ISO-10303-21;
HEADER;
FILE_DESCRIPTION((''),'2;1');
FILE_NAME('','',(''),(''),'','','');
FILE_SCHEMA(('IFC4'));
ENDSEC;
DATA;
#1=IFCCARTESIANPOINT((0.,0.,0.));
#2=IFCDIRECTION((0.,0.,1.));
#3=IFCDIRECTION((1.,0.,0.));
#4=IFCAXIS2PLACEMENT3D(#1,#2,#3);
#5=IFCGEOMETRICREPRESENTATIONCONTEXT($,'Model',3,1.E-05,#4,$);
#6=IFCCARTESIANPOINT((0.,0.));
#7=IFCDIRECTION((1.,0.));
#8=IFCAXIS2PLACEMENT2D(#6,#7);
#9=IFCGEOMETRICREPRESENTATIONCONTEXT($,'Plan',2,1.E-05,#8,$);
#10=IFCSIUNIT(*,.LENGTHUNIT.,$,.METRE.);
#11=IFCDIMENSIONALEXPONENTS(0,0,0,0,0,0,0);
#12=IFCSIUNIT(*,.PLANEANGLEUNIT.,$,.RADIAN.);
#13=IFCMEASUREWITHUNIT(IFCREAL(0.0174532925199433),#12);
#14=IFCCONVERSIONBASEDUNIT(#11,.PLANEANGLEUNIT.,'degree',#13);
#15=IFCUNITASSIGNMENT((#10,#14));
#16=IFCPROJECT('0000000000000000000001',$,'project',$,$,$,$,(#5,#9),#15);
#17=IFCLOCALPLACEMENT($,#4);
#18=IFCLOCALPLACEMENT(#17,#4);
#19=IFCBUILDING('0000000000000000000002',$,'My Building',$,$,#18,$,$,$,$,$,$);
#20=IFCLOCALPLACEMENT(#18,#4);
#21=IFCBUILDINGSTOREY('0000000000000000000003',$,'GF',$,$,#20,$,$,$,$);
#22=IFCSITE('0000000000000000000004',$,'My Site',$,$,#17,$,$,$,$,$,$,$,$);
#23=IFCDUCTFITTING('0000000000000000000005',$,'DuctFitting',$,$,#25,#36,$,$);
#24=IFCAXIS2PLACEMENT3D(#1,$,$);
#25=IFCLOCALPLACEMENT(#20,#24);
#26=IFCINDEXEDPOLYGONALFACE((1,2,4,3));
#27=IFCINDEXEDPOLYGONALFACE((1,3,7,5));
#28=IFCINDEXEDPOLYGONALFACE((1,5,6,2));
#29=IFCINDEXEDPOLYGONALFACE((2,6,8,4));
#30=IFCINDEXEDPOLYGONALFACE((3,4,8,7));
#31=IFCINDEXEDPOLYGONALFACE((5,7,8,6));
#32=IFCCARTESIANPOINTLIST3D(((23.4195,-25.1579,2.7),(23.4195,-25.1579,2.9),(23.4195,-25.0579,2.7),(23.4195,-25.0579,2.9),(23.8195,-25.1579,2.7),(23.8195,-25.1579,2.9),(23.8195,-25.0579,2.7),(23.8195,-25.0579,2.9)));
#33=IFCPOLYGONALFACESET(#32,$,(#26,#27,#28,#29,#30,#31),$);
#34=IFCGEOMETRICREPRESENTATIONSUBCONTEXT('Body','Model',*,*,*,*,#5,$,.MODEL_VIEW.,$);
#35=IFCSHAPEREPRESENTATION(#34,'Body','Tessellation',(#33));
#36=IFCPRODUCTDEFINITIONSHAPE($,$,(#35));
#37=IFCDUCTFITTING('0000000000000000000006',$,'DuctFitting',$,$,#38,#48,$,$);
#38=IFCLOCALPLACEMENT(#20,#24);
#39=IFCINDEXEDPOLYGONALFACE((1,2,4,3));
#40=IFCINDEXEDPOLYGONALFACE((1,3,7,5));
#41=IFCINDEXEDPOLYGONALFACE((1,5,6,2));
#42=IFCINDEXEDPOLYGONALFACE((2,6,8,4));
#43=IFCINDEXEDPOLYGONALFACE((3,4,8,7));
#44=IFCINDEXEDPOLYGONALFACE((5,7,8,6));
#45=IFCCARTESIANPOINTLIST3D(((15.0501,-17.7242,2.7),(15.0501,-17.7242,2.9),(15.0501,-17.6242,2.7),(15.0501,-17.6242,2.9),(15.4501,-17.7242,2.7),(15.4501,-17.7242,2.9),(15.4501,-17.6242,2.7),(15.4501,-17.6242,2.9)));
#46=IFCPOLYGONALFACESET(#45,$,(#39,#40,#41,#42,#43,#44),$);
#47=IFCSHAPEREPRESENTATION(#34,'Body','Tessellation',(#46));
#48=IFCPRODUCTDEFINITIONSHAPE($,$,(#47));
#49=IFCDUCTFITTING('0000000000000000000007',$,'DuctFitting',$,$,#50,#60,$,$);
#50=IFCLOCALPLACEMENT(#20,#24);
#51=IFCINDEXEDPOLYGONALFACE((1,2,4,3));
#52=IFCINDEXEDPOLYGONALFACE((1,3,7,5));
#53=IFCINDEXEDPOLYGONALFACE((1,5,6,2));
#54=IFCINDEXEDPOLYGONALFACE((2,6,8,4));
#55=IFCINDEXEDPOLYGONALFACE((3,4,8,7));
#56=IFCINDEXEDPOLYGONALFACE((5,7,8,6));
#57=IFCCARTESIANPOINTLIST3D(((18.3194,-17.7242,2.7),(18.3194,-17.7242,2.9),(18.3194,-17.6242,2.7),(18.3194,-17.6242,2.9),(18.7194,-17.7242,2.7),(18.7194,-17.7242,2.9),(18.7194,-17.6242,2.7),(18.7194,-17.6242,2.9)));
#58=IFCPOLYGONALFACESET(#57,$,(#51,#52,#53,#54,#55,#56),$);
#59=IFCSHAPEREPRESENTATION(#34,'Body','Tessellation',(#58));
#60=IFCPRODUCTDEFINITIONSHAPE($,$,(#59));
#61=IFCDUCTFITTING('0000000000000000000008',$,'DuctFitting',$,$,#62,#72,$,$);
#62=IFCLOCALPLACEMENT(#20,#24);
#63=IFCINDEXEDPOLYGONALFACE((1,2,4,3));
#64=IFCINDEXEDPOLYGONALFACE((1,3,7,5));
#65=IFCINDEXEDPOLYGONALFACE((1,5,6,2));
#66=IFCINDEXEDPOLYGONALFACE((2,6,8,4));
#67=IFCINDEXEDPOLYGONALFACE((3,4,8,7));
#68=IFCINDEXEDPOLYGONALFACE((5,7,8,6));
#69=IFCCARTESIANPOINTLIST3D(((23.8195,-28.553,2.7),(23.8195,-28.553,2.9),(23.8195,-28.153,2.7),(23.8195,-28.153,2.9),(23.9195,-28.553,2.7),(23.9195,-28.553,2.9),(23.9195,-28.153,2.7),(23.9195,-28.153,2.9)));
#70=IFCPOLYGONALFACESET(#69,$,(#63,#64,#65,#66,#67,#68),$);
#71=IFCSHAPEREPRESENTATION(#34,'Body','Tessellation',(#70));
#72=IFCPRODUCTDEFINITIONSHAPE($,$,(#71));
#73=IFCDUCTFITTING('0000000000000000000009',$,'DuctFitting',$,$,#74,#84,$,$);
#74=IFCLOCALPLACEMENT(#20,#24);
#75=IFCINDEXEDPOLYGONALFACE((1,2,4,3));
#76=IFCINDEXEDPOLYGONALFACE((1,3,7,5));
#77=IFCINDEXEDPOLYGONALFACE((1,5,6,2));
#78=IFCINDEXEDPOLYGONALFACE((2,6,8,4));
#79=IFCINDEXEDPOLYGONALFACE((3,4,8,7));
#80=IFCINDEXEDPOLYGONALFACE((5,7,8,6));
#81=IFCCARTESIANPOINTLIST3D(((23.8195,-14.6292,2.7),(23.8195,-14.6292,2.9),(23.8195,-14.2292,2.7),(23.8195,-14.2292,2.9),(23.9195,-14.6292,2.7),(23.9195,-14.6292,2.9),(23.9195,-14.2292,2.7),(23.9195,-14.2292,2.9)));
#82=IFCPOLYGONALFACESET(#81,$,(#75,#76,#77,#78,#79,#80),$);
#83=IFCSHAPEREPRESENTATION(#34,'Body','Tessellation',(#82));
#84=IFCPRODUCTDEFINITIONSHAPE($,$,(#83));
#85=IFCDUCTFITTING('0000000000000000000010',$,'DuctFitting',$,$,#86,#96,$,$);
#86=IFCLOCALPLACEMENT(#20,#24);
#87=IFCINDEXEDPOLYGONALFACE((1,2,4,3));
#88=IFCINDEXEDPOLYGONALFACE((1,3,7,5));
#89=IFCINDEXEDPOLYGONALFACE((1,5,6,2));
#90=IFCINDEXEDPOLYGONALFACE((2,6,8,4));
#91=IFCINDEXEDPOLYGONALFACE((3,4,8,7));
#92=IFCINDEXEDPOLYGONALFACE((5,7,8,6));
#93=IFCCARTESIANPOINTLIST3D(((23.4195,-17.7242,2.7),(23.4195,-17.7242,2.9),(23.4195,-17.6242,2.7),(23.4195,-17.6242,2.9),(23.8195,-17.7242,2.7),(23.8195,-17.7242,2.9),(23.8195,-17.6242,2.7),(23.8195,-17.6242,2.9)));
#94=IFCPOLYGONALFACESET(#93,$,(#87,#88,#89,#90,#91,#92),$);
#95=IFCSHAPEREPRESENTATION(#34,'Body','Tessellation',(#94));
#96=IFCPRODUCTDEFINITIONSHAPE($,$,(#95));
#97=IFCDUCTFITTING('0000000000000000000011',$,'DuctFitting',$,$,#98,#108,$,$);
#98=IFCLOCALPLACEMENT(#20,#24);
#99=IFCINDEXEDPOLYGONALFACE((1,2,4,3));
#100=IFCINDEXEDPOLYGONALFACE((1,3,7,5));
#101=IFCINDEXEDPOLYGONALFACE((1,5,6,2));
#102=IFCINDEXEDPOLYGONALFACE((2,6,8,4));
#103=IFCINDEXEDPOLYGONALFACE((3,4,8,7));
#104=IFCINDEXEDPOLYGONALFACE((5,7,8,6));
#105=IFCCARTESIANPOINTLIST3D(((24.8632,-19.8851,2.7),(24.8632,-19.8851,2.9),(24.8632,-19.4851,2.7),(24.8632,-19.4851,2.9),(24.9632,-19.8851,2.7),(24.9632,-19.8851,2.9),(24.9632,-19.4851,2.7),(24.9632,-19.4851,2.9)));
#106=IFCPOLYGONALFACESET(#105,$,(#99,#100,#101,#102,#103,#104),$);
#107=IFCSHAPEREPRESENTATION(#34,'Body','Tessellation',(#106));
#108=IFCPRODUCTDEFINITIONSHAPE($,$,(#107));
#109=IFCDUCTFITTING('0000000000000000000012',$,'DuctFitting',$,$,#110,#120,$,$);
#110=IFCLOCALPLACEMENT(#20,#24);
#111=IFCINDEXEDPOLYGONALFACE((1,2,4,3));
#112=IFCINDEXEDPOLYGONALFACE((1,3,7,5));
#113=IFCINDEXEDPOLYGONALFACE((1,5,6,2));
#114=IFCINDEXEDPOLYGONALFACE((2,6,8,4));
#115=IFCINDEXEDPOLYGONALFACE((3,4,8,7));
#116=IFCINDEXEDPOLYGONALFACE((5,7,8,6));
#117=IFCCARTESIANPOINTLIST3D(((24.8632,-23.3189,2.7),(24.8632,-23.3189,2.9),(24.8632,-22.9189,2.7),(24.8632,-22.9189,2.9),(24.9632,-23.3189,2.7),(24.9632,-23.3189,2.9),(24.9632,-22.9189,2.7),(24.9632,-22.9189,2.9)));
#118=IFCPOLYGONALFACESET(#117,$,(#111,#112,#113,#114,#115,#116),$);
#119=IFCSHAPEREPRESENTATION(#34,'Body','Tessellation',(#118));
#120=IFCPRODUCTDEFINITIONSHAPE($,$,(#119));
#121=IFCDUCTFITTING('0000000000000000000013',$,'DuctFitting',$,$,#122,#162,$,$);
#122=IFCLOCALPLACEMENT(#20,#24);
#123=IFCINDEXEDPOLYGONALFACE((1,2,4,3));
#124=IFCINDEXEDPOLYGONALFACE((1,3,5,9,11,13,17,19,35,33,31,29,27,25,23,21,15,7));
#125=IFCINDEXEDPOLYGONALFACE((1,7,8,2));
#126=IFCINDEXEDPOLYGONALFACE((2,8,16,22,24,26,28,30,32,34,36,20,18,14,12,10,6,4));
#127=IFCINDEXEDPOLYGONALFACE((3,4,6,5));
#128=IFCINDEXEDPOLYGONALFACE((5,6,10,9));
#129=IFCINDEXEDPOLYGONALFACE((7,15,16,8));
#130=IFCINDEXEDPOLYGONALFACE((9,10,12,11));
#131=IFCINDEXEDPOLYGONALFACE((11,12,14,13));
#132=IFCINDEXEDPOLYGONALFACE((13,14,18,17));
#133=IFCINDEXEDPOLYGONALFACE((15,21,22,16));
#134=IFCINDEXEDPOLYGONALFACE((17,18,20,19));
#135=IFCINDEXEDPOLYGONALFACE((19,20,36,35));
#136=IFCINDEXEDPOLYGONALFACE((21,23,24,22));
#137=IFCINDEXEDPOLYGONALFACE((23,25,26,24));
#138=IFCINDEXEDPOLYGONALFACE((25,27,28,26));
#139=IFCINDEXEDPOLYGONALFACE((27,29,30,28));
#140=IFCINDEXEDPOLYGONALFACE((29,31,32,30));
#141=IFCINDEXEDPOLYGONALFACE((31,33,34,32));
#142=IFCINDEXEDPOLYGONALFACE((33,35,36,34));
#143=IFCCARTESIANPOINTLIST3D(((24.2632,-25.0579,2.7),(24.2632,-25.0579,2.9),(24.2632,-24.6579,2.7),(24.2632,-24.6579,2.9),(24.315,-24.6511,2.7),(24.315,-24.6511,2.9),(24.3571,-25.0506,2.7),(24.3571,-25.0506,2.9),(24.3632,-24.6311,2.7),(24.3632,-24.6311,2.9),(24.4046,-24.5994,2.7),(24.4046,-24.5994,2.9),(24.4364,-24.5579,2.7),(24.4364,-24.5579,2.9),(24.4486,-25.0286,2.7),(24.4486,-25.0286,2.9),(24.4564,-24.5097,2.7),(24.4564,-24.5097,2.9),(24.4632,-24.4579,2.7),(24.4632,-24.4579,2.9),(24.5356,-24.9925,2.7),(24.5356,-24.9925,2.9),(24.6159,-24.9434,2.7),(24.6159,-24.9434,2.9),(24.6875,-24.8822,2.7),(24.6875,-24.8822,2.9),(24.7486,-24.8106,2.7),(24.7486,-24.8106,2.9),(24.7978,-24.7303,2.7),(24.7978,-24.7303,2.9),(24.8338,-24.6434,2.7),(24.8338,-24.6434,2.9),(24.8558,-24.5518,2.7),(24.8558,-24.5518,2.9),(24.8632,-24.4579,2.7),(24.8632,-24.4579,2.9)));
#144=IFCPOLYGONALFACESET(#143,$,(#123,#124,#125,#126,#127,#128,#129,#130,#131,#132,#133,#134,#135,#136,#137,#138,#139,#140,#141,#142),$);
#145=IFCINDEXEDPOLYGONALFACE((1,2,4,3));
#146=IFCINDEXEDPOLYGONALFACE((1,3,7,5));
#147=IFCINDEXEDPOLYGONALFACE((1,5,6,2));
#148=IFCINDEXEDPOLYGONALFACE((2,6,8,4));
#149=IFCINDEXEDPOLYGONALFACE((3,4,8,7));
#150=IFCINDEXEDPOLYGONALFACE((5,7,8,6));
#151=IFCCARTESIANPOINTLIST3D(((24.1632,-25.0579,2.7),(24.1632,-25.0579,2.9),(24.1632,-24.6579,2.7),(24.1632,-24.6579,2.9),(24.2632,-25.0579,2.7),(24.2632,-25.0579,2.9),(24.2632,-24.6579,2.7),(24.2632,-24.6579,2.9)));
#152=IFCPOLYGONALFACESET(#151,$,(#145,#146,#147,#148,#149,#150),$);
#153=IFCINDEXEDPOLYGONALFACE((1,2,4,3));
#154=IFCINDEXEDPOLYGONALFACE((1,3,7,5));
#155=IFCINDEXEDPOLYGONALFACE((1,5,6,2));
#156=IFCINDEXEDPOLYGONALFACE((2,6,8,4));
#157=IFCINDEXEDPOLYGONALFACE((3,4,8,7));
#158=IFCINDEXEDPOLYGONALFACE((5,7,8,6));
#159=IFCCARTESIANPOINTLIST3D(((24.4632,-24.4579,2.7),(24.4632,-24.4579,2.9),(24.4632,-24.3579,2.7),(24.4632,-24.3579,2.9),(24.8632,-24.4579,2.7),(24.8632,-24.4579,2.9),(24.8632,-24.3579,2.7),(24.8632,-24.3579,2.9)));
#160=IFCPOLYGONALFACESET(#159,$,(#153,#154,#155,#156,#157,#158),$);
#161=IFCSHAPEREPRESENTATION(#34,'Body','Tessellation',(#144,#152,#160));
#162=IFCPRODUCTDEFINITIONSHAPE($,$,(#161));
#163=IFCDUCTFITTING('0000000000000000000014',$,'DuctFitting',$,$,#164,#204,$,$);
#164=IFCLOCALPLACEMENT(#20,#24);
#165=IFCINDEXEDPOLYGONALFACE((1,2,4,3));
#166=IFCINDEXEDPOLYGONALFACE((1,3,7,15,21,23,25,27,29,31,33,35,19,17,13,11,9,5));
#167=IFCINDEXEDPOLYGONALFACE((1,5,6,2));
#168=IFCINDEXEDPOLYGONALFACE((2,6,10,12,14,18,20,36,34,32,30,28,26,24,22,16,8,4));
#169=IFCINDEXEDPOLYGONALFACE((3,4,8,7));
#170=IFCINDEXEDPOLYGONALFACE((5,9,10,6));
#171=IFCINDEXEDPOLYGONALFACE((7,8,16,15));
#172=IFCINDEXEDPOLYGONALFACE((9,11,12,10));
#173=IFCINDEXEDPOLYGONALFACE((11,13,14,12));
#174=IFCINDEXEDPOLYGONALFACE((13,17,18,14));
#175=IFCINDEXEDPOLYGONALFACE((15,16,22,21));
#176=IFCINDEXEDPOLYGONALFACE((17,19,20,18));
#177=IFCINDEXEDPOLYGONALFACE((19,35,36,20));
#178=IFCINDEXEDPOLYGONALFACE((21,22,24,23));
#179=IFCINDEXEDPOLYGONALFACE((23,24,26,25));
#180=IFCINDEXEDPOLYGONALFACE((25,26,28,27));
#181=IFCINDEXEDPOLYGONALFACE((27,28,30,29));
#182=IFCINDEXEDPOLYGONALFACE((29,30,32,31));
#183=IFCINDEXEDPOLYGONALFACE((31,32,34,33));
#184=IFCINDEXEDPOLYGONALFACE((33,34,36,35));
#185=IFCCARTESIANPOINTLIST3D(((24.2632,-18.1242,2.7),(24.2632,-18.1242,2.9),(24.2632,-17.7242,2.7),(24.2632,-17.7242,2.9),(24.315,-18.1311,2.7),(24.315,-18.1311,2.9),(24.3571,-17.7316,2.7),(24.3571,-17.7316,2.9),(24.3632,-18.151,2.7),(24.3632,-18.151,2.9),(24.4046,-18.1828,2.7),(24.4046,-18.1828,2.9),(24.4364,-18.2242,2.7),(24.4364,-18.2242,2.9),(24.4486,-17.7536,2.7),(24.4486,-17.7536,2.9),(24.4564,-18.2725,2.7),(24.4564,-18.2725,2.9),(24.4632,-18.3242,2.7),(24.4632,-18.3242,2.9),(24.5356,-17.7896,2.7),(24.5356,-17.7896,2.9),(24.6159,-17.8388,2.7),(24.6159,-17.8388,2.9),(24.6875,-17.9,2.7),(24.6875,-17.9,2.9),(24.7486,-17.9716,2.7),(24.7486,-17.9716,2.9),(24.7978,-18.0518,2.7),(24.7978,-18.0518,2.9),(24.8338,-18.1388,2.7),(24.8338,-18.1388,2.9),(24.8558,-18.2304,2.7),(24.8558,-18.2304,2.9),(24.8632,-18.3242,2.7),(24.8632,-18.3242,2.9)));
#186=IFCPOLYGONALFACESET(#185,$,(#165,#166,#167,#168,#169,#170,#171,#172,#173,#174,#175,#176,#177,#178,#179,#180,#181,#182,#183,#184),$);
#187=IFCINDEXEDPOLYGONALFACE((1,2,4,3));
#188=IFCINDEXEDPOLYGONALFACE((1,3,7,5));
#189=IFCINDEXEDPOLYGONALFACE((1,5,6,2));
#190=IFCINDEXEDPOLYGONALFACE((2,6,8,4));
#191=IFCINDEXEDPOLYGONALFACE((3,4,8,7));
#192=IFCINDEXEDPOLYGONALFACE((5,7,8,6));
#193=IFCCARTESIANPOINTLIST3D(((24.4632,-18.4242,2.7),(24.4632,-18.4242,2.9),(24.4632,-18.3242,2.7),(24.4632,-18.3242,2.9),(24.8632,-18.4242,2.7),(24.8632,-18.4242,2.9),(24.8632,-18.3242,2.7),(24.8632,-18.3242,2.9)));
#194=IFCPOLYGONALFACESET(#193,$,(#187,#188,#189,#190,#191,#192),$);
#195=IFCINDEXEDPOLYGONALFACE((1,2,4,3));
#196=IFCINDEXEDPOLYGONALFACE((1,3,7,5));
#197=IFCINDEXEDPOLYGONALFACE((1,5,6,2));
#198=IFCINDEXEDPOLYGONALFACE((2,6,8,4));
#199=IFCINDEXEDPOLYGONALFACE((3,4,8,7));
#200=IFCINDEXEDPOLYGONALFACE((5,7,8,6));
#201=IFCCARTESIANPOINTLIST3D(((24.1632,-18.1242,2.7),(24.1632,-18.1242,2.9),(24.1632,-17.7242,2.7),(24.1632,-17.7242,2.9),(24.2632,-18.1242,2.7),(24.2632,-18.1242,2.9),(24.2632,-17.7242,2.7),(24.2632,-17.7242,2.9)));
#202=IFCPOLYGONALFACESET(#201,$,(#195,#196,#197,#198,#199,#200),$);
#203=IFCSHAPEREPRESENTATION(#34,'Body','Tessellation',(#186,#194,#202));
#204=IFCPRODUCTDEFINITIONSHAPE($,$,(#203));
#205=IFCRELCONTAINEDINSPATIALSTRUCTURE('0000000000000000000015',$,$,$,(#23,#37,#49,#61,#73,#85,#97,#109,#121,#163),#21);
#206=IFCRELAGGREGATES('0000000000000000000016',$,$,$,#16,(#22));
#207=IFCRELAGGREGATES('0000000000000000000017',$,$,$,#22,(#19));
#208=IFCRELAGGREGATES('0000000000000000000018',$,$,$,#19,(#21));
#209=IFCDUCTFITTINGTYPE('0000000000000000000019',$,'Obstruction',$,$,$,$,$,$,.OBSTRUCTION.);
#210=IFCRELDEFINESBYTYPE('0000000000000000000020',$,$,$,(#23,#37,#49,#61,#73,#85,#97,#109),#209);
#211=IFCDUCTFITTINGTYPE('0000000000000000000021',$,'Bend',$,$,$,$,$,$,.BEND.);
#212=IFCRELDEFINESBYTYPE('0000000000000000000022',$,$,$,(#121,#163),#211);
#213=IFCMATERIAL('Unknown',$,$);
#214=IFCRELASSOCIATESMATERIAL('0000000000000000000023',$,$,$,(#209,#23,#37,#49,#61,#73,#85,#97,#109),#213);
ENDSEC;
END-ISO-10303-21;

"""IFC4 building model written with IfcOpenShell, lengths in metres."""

from ifc_helpers import new_model, entity, si_unit, converted_unit, frame, origin_with_axes, origin_2d_with_axis, place, context, subcontext, project, spatial, line, arc, indexed_curve, rectangle, outline, extrude, source, transform, mapped, material, material_profile, profile_set, profile_usage, type_object, type_shapes, element, save


model = new_model("IFC4")

# Units and contexts
model_context = context("Model", 3, precision=1e-05, world=origin_with_axes())
plan_context = context("Plan", 2, precision=1e-05, world=origin_2d_with_axis())
body_context_1 = subcontext(model_context, "Body", "Model", "MODEL_VIEW")
ifc_project = project(units=[si_unit("LENGTHUNIT", "METRE"), converted_unit("PLANEANGLEUNIT", "degree", entity("IfcReal", 0.0174532925199433), si_unit("PLANEANGLEUNIT", "RADIAN"), dimensions=[0, 0, 0, 0, 0, 0, 0])], contexts=[model_context, plan_context])

# Site, building, storey
site_placement = place(None, origin_with_axes())
site = spatial("IfcSite", under=ifc_project, at=site_placement, Name="My Site")
building_placement = place(site_placement, origin_with_axes())
building = spatial("IfcBuilding", under=site, at=building_placement, Name="My Building")
storey_placement = place(building_placement, origin_with_axes())
storey = spatial("IfcBuildingStorey", under=building, at=storey_placement, Name="GF")

# Shared definitions
ifc_material = material(Name="Unknown")

# Duct fittings
ifc_material_profile_1 = material_profile(ifc_material, rectangle(XDim=0.4, YDim=0.2))
ifc_profile_set_1 = profile_set([ifc_material_profile_1])
duct_fitting_type_1 = type_object("IfcDuctFittingType", Name="Obstruction", PredefinedType="OBSTRUCTION", material=ifc_profile_set_1)
ifc_profile_usage_1 = profile_usage(ifc_profile_set_1, cardinal=5)
duct_fitting_1_placement = place(storey_placement, frame((23.6195, -25.0579, 2.8), z_axis=(0.0, -1.0, 0.0), x_axis=(1.0, 0.0, 0.0)))
element("IfcDuctFitting", 1, at=duct_fitting_1_placement, inside=storey, type_object=duct_fitting_type_1, material=ifc_profile_usage_1, Name="DuctFitting", context=body_context_1, shape_type="SweptSolid", body=[
    extrude(rectangle(XDim=0.4, YDim=0.2), origin_with_axes(), (0.0, 0.0, 1.0), 0.1),
])
ifc_profile_usage_2 = profile_usage(ifc_profile_set_1, cardinal=5)
duct_fitting_2_placement = place(storey_placement, frame((15.2501, -17.7242, 2.8), z_axis=(0.0, 1.0, 0.0), x_axis=(-1.0, 0.0, 0.0)))
element("IfcDuctFitting", 2, at=duct_fitting_2_placement, inside=storey, type_object=duct_fitting_type_1, material=ifc_profile_usage_2, Name="DuctFitting", context=body_context_1, shape_type="SweptSolid", body=[
    extrude(rectangle(XDim=0.4, YDim=0.2), origin_with_axes(), (0.0, 0.0, 1.0), 0.1),
])
ifc_profile_usage_3 = profile_usage(ifc_profile_set_1, cardinal=5)
duct_fitting_3_placement = place(storey_placement, frame((18.5194, -17.7242, 2.8), z_axis=(0.0, 1.0, 0.0), x_axis=(-1.0, 0.0, 0.0)))
element("IfcDuctFitting", 3, at=duct_fitting_3_placement, inside=storey, type_object=duct_fitting_type_1, material=ifc_profile_usage_3, Name="DuctFitting", context=body_context_1, shape_type="SweptSolid", body=[
    extrude(rectangle(XDim=0.4, YDim=0.2), origin_with_axes(), (0.0, 0.0, 1.0), 0.1),
])
ifc_profile_usage_4 = profile_usage(ifc_profile_set_1, cardinal=5)
duct_fitting_4_placement = place(storey_placement, frame((23.8195, -28.353, 2.8), z_axis=(1.0, 0.0, 0.0), x_axis=(0.0, 1.0, 0.0)))
element("IfcDuctFitting", 4, at=duct_fitting_4_placement, inside=storey, type_object=duct_fitting_type_1, material=ifc_profile_usage_4, Name="DuctFitting", context=body_context_1, shape_type="SweptSolid", body=[
    extrude(rectangle(XDim=0.4, YDim=0.2), origin_with_axes(), (0.0, 0.0, 1.0), 0.1),
])
ifc_profile_usage_5 = profile_usage(ifc_profile_set_1, cardinal=5)
duct_fitting_5_placement = place(storey_placement, frame((23.8195, -14.4292, 2.8), z_axis=(1.0, 0.0, 0.00005), x_axis=(0.0, -1.0, 0.0)))
element("IfcDuctFitting", 5, at=duct_fitting_5_placement, inside=storey, type_object=duct_fitting_type_1, material=ifc_profile_usage_5, Name="DuctFitting", context=body_context_1, shape_type="SweptSolid", body=[
    extrude(rectangle(XDim=0.4, YDim=0.2), origin_with_axes(), (0.0, 0.0, 1.0), 0.1),
])
ifc_profile_usage_6 = profile_usage(ifc_profile_set_1, cardinal=5)
duct_fitting_6_placement = place(storey_placement, frame((23.6195, -17.7242, 2.8), z_axis=(0.0, 1.0, 0.0), x_axis=(1.0, 0.0, -0.000004)))
element("IfcDuctFitting", 6, at=duct_fitting_6_placement, inside=storey, type_object=duct_fitting_type_1, material=ifc_profile_usage_6, Name="DuctFitting", context=body_context_1, shape_type="SweptSolid", body=[
    extrude(rectangle(XDim=0.4, YDim=0.2), origin_with_axes(), (0.0, 0.0, 1.0), 0.1),
])
ifc_profile_usage_7 = profile_usage(ifc_profile_set_1, cardinal=5)
duct_fitting_7_placement = place(storey_placement, frame((24.8632, -19.6851, 2.8), z_axis=(1.0, 0.0, 0.00005), x_axis=(0.0, -1.0, 0.0)))
element("IfcDuctFitting", 7, at=duct_fitting_7_placement, inside=storey, type_object=duct_fitting_type_1, material=ifc_profile_usage_7, Name="DuctFitting", context=body_context_1, shape_type="SweptSolid", body=[
    extrude(rectangle(XDim=0.4, YDim=0.2), origin_with_axes(), (0.0, 0.0, 1.0), 0.1),
])
ifc_profile_usage_8 = profile_usage(ifc_profile_set_1, cardinal=5)
duct_fitting_8_placement = place(storey_placement, frame((24.8632, -23.1189, 2.8), z_axis=(1.0, 0.0, 0.00005), x_axis=(0.0, -1.0, 0.0)))
element("IfcDuctFitting", 8, at=duct_fitting_8_placement, inside=storey, type_object=duct_fitting_type_1, material=ifc_profile_usage_8, Name="DuctFitting", context=body_context_1, shape_type="SweptSolid", body=[
    extrude(rectangle(XDim=0.4, YDim=0.2), origin_with_axes(), (0.0, 0.0, 1.0), 0.1),
])
duct_fitting_type_2 = type_object("IfcDuctFittingType", Name="Bend", PredefinedType="BEND")
shared_shape_1 = source(origin_with_axes(), body_context_1, "Body", "SweptSolid", [
    extrude(outline(indexed_curve([(0.2, 0.0), (0.2586, 0.1414), (0.4, 0.2), (0.4, 0.6), (-0.0243, 0.4243), (-0.2, 0.0)], segments=[arc(1, 2, 3), line(3, 4), arc(4, 5, 6), line(6, 1)])), frame((0.0, -0.1, 0.1), z_axis=(0.0, -1.0, 0.0), x_axis=(1.0, 0.0, 0.0)), (0.0, 0.0, -1.0), 0.2),
    extrude(rectangle(XDim=0.4, YDim=0.2), origin_with_axes(), (0.0, 0.0, 1.0), 0.1),
    extrude(rectangle(XDim=0.4, YDim=0.2), frame((0.4, 0.0, 0.5), z_axis=(1.0, 0.0, 0.0), x_axis=(0.0, 0.0, 1.0)), (0.0, 0.0, 1.0), 0.1),
])
type_shapes(duct_fitting_type_2, [shared_shape_1])
for number, where, z_axis, x_axis, name in (
    (9, (24.1632, -24.8579, 2.8), (1.0, 0.0, 0.0), (0.0, 1.0, 0.0), "DuctFitting"),
    (10, (24.6632, -18.4242, 2.8), (0.0, 1.0, 0.0), (-1.0, 0.0, 0.0), "DuctFitting"),
):
    element("IfcDuctFitting", number, at=place(storey_placement, frame(where, z_axis=z_axis, x_axis=x_axis)), inside=storey, type_object=duct_fitting_type_2, Name=name, context=body_context_1, shape_type="MappedRepresentation", body=[
        mapped(shared_shape_1, transform((0.0, 0.0, 0.0), x_axis=(1.0, 0.0, 0.0), y_axis=(0.0, 1.0, 0.0), z_axis=(0.0, 0.0, 1.0), scale=1.0)),
    ])

save(model, "model.ifc")
